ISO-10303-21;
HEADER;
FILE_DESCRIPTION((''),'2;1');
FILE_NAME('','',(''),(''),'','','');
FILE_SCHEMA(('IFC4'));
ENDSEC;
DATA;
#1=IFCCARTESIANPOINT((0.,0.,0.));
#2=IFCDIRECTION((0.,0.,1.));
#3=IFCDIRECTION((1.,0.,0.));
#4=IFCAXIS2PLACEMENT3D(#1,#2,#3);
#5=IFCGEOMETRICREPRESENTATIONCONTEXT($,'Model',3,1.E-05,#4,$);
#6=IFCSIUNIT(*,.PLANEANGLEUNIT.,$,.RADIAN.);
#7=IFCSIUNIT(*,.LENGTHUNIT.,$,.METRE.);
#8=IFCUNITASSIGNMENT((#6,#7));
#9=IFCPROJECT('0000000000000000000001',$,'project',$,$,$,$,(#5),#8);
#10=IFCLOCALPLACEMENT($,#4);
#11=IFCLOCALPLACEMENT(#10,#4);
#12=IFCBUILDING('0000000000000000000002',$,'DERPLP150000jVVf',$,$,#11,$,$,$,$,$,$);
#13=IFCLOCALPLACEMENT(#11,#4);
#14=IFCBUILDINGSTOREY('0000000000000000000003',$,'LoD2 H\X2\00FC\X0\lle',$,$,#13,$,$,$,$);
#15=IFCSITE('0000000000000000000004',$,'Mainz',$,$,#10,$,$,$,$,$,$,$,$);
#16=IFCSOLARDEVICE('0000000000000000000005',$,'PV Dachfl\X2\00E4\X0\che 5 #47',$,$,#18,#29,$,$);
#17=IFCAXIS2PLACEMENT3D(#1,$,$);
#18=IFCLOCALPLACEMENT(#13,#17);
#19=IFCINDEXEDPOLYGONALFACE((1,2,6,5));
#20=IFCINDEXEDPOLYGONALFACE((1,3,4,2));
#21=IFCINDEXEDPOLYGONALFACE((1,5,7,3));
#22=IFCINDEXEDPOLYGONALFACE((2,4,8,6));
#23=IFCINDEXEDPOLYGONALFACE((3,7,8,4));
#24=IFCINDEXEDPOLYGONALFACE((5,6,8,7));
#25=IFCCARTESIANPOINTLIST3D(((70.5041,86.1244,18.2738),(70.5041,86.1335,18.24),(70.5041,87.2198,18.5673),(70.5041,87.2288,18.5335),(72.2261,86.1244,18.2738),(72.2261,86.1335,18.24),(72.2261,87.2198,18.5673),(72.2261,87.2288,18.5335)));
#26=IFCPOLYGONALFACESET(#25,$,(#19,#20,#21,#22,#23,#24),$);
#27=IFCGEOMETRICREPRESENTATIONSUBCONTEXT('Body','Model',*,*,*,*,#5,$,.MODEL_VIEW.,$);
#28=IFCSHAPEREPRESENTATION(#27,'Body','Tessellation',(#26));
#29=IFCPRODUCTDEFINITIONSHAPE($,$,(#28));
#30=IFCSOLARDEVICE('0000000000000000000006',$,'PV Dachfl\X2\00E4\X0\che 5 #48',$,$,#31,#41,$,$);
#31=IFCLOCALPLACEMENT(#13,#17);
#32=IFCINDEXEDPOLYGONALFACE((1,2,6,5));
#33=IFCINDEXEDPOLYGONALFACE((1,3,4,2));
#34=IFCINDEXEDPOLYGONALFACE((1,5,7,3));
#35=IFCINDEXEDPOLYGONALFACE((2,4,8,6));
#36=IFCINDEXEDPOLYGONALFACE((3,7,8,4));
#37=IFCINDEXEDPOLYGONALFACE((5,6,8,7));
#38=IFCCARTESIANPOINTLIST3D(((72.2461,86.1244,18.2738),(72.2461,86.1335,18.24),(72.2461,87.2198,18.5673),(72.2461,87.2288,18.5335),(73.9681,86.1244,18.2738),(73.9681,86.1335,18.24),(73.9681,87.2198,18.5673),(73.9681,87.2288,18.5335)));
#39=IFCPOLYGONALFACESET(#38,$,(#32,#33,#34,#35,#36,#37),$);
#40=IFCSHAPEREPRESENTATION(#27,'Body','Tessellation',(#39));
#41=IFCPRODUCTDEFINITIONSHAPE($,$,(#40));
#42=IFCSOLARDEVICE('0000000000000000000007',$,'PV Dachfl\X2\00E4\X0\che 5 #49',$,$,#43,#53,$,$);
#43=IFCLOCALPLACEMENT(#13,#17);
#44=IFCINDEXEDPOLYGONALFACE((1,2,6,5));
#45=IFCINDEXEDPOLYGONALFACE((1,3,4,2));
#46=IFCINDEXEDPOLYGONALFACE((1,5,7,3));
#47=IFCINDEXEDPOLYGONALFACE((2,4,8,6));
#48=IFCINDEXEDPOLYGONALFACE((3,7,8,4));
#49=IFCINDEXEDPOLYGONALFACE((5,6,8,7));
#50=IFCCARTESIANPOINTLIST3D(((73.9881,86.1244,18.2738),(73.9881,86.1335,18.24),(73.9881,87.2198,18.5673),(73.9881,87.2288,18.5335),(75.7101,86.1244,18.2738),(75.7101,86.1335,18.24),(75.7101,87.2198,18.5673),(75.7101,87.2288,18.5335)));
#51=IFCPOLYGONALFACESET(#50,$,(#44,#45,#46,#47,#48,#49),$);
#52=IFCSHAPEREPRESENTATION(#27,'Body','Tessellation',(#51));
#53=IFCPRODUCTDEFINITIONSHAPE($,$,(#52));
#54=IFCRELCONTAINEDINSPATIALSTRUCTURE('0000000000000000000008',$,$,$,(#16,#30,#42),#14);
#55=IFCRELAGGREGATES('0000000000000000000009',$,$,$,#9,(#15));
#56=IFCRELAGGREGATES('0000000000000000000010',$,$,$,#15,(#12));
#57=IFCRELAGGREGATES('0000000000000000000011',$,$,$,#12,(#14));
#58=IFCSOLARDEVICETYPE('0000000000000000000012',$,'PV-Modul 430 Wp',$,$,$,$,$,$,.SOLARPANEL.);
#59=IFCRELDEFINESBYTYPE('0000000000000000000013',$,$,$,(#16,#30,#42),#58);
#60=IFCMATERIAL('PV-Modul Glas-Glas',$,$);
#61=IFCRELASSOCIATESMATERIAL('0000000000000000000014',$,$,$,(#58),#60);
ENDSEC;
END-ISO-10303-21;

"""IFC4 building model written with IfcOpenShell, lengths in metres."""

from ifc_helpers import new_model, si_unit, frame, frame_2d, origin, origin_with_axes, place, context, subcontext, project, spatial, rectangle, extrude, source, transform, mapped, material, type_object, type_shapes, element, save


model = new_model("IFC4")

# Units and contexts
model_context = context("Model", 3, precision=1e-05, world=origin_with_axes())
body_context = subcontext(model_context, "Body", "Model", "MODEL_VIEW")
ifc_project = project(units=[si_unit("PLANEANGLEUNIT", "RADIAN"), si_unit("LENGTHUNIT", "METRE")], contexts=[model_context])

# Site, building, storey
site_placement = place(None, origin_with_axes())
site = spatial("IfcSite", under=ifc_project, at=site_placement, Name="Mainz")
building_placement = place(site_placement, origin_with_axes())
building = spatial("IfcBuilding", under=site, at=building_placement, Name="DERPLP150000jVVf")
storey_placement = place(building_placement, origin_with_axes())
storey = spatial("IfcBuildingStorey", under=building, at=storey_placement, Name="LoD2 Hülle")

# Solar devices
ifc_material = material(Name="PV-Modul Glas-Glas")
solar_device_type = type_object("IfcSolarDeviceType", Name="PV-Modul 430 Wp", PredefinedType="SOLARPANEL", material=ifc_material)
shared_shape = source(origin_with_axes(), body_context, "Body", "SweptSolid", [
    extrude(rectangle(XDim=1.722, YDim=1.134, at=frame_2d((0.861, 0.567))), origin(), (0.0, 0.0, 1.0), 0.035),
])
type_shapes(solar_device_type, [shared_shape])
for number, where, z_axis, x_axis, name in (
    (1, (70.5041, 86.1335, 18.24), (0.0, -0.258819, 0.965926), (1.0, 0.0, 0.0), "PV Dachfläche 5 #47"),
    (2, (72.2461, 86.1335, 18.24), (0.0, -0.258819, 0.965926), (1.0, 0.0, 0.0), "PV Dachfläche 5 #48"),
    (3, (73.9881, 86.1335, 18.24), (0.0, -0.258819, 0.965926), (1.0, 0.0, 0.0), "PV Dachfläche 5 #49"),
):
    element("IfcSolarDevice", number, at=place(storey_placement, frame(where, z_axis=z_axis, x_axis=x_axis)), inside=storey, type_object=solar_device_type, Name=name, context=body_context, shape_type="MappedRepresentation", body=[
        mapped(shared_shape, transform((0.0, 0.0, 0.0), x_axis=(1.0, 0.0, 0.0), y_axis=(0.0, 1.0, 0.0), z_axis=(0.0, 0.0, 1.0), scale=1.0)),
    ])

save(model, "model.ifc")
